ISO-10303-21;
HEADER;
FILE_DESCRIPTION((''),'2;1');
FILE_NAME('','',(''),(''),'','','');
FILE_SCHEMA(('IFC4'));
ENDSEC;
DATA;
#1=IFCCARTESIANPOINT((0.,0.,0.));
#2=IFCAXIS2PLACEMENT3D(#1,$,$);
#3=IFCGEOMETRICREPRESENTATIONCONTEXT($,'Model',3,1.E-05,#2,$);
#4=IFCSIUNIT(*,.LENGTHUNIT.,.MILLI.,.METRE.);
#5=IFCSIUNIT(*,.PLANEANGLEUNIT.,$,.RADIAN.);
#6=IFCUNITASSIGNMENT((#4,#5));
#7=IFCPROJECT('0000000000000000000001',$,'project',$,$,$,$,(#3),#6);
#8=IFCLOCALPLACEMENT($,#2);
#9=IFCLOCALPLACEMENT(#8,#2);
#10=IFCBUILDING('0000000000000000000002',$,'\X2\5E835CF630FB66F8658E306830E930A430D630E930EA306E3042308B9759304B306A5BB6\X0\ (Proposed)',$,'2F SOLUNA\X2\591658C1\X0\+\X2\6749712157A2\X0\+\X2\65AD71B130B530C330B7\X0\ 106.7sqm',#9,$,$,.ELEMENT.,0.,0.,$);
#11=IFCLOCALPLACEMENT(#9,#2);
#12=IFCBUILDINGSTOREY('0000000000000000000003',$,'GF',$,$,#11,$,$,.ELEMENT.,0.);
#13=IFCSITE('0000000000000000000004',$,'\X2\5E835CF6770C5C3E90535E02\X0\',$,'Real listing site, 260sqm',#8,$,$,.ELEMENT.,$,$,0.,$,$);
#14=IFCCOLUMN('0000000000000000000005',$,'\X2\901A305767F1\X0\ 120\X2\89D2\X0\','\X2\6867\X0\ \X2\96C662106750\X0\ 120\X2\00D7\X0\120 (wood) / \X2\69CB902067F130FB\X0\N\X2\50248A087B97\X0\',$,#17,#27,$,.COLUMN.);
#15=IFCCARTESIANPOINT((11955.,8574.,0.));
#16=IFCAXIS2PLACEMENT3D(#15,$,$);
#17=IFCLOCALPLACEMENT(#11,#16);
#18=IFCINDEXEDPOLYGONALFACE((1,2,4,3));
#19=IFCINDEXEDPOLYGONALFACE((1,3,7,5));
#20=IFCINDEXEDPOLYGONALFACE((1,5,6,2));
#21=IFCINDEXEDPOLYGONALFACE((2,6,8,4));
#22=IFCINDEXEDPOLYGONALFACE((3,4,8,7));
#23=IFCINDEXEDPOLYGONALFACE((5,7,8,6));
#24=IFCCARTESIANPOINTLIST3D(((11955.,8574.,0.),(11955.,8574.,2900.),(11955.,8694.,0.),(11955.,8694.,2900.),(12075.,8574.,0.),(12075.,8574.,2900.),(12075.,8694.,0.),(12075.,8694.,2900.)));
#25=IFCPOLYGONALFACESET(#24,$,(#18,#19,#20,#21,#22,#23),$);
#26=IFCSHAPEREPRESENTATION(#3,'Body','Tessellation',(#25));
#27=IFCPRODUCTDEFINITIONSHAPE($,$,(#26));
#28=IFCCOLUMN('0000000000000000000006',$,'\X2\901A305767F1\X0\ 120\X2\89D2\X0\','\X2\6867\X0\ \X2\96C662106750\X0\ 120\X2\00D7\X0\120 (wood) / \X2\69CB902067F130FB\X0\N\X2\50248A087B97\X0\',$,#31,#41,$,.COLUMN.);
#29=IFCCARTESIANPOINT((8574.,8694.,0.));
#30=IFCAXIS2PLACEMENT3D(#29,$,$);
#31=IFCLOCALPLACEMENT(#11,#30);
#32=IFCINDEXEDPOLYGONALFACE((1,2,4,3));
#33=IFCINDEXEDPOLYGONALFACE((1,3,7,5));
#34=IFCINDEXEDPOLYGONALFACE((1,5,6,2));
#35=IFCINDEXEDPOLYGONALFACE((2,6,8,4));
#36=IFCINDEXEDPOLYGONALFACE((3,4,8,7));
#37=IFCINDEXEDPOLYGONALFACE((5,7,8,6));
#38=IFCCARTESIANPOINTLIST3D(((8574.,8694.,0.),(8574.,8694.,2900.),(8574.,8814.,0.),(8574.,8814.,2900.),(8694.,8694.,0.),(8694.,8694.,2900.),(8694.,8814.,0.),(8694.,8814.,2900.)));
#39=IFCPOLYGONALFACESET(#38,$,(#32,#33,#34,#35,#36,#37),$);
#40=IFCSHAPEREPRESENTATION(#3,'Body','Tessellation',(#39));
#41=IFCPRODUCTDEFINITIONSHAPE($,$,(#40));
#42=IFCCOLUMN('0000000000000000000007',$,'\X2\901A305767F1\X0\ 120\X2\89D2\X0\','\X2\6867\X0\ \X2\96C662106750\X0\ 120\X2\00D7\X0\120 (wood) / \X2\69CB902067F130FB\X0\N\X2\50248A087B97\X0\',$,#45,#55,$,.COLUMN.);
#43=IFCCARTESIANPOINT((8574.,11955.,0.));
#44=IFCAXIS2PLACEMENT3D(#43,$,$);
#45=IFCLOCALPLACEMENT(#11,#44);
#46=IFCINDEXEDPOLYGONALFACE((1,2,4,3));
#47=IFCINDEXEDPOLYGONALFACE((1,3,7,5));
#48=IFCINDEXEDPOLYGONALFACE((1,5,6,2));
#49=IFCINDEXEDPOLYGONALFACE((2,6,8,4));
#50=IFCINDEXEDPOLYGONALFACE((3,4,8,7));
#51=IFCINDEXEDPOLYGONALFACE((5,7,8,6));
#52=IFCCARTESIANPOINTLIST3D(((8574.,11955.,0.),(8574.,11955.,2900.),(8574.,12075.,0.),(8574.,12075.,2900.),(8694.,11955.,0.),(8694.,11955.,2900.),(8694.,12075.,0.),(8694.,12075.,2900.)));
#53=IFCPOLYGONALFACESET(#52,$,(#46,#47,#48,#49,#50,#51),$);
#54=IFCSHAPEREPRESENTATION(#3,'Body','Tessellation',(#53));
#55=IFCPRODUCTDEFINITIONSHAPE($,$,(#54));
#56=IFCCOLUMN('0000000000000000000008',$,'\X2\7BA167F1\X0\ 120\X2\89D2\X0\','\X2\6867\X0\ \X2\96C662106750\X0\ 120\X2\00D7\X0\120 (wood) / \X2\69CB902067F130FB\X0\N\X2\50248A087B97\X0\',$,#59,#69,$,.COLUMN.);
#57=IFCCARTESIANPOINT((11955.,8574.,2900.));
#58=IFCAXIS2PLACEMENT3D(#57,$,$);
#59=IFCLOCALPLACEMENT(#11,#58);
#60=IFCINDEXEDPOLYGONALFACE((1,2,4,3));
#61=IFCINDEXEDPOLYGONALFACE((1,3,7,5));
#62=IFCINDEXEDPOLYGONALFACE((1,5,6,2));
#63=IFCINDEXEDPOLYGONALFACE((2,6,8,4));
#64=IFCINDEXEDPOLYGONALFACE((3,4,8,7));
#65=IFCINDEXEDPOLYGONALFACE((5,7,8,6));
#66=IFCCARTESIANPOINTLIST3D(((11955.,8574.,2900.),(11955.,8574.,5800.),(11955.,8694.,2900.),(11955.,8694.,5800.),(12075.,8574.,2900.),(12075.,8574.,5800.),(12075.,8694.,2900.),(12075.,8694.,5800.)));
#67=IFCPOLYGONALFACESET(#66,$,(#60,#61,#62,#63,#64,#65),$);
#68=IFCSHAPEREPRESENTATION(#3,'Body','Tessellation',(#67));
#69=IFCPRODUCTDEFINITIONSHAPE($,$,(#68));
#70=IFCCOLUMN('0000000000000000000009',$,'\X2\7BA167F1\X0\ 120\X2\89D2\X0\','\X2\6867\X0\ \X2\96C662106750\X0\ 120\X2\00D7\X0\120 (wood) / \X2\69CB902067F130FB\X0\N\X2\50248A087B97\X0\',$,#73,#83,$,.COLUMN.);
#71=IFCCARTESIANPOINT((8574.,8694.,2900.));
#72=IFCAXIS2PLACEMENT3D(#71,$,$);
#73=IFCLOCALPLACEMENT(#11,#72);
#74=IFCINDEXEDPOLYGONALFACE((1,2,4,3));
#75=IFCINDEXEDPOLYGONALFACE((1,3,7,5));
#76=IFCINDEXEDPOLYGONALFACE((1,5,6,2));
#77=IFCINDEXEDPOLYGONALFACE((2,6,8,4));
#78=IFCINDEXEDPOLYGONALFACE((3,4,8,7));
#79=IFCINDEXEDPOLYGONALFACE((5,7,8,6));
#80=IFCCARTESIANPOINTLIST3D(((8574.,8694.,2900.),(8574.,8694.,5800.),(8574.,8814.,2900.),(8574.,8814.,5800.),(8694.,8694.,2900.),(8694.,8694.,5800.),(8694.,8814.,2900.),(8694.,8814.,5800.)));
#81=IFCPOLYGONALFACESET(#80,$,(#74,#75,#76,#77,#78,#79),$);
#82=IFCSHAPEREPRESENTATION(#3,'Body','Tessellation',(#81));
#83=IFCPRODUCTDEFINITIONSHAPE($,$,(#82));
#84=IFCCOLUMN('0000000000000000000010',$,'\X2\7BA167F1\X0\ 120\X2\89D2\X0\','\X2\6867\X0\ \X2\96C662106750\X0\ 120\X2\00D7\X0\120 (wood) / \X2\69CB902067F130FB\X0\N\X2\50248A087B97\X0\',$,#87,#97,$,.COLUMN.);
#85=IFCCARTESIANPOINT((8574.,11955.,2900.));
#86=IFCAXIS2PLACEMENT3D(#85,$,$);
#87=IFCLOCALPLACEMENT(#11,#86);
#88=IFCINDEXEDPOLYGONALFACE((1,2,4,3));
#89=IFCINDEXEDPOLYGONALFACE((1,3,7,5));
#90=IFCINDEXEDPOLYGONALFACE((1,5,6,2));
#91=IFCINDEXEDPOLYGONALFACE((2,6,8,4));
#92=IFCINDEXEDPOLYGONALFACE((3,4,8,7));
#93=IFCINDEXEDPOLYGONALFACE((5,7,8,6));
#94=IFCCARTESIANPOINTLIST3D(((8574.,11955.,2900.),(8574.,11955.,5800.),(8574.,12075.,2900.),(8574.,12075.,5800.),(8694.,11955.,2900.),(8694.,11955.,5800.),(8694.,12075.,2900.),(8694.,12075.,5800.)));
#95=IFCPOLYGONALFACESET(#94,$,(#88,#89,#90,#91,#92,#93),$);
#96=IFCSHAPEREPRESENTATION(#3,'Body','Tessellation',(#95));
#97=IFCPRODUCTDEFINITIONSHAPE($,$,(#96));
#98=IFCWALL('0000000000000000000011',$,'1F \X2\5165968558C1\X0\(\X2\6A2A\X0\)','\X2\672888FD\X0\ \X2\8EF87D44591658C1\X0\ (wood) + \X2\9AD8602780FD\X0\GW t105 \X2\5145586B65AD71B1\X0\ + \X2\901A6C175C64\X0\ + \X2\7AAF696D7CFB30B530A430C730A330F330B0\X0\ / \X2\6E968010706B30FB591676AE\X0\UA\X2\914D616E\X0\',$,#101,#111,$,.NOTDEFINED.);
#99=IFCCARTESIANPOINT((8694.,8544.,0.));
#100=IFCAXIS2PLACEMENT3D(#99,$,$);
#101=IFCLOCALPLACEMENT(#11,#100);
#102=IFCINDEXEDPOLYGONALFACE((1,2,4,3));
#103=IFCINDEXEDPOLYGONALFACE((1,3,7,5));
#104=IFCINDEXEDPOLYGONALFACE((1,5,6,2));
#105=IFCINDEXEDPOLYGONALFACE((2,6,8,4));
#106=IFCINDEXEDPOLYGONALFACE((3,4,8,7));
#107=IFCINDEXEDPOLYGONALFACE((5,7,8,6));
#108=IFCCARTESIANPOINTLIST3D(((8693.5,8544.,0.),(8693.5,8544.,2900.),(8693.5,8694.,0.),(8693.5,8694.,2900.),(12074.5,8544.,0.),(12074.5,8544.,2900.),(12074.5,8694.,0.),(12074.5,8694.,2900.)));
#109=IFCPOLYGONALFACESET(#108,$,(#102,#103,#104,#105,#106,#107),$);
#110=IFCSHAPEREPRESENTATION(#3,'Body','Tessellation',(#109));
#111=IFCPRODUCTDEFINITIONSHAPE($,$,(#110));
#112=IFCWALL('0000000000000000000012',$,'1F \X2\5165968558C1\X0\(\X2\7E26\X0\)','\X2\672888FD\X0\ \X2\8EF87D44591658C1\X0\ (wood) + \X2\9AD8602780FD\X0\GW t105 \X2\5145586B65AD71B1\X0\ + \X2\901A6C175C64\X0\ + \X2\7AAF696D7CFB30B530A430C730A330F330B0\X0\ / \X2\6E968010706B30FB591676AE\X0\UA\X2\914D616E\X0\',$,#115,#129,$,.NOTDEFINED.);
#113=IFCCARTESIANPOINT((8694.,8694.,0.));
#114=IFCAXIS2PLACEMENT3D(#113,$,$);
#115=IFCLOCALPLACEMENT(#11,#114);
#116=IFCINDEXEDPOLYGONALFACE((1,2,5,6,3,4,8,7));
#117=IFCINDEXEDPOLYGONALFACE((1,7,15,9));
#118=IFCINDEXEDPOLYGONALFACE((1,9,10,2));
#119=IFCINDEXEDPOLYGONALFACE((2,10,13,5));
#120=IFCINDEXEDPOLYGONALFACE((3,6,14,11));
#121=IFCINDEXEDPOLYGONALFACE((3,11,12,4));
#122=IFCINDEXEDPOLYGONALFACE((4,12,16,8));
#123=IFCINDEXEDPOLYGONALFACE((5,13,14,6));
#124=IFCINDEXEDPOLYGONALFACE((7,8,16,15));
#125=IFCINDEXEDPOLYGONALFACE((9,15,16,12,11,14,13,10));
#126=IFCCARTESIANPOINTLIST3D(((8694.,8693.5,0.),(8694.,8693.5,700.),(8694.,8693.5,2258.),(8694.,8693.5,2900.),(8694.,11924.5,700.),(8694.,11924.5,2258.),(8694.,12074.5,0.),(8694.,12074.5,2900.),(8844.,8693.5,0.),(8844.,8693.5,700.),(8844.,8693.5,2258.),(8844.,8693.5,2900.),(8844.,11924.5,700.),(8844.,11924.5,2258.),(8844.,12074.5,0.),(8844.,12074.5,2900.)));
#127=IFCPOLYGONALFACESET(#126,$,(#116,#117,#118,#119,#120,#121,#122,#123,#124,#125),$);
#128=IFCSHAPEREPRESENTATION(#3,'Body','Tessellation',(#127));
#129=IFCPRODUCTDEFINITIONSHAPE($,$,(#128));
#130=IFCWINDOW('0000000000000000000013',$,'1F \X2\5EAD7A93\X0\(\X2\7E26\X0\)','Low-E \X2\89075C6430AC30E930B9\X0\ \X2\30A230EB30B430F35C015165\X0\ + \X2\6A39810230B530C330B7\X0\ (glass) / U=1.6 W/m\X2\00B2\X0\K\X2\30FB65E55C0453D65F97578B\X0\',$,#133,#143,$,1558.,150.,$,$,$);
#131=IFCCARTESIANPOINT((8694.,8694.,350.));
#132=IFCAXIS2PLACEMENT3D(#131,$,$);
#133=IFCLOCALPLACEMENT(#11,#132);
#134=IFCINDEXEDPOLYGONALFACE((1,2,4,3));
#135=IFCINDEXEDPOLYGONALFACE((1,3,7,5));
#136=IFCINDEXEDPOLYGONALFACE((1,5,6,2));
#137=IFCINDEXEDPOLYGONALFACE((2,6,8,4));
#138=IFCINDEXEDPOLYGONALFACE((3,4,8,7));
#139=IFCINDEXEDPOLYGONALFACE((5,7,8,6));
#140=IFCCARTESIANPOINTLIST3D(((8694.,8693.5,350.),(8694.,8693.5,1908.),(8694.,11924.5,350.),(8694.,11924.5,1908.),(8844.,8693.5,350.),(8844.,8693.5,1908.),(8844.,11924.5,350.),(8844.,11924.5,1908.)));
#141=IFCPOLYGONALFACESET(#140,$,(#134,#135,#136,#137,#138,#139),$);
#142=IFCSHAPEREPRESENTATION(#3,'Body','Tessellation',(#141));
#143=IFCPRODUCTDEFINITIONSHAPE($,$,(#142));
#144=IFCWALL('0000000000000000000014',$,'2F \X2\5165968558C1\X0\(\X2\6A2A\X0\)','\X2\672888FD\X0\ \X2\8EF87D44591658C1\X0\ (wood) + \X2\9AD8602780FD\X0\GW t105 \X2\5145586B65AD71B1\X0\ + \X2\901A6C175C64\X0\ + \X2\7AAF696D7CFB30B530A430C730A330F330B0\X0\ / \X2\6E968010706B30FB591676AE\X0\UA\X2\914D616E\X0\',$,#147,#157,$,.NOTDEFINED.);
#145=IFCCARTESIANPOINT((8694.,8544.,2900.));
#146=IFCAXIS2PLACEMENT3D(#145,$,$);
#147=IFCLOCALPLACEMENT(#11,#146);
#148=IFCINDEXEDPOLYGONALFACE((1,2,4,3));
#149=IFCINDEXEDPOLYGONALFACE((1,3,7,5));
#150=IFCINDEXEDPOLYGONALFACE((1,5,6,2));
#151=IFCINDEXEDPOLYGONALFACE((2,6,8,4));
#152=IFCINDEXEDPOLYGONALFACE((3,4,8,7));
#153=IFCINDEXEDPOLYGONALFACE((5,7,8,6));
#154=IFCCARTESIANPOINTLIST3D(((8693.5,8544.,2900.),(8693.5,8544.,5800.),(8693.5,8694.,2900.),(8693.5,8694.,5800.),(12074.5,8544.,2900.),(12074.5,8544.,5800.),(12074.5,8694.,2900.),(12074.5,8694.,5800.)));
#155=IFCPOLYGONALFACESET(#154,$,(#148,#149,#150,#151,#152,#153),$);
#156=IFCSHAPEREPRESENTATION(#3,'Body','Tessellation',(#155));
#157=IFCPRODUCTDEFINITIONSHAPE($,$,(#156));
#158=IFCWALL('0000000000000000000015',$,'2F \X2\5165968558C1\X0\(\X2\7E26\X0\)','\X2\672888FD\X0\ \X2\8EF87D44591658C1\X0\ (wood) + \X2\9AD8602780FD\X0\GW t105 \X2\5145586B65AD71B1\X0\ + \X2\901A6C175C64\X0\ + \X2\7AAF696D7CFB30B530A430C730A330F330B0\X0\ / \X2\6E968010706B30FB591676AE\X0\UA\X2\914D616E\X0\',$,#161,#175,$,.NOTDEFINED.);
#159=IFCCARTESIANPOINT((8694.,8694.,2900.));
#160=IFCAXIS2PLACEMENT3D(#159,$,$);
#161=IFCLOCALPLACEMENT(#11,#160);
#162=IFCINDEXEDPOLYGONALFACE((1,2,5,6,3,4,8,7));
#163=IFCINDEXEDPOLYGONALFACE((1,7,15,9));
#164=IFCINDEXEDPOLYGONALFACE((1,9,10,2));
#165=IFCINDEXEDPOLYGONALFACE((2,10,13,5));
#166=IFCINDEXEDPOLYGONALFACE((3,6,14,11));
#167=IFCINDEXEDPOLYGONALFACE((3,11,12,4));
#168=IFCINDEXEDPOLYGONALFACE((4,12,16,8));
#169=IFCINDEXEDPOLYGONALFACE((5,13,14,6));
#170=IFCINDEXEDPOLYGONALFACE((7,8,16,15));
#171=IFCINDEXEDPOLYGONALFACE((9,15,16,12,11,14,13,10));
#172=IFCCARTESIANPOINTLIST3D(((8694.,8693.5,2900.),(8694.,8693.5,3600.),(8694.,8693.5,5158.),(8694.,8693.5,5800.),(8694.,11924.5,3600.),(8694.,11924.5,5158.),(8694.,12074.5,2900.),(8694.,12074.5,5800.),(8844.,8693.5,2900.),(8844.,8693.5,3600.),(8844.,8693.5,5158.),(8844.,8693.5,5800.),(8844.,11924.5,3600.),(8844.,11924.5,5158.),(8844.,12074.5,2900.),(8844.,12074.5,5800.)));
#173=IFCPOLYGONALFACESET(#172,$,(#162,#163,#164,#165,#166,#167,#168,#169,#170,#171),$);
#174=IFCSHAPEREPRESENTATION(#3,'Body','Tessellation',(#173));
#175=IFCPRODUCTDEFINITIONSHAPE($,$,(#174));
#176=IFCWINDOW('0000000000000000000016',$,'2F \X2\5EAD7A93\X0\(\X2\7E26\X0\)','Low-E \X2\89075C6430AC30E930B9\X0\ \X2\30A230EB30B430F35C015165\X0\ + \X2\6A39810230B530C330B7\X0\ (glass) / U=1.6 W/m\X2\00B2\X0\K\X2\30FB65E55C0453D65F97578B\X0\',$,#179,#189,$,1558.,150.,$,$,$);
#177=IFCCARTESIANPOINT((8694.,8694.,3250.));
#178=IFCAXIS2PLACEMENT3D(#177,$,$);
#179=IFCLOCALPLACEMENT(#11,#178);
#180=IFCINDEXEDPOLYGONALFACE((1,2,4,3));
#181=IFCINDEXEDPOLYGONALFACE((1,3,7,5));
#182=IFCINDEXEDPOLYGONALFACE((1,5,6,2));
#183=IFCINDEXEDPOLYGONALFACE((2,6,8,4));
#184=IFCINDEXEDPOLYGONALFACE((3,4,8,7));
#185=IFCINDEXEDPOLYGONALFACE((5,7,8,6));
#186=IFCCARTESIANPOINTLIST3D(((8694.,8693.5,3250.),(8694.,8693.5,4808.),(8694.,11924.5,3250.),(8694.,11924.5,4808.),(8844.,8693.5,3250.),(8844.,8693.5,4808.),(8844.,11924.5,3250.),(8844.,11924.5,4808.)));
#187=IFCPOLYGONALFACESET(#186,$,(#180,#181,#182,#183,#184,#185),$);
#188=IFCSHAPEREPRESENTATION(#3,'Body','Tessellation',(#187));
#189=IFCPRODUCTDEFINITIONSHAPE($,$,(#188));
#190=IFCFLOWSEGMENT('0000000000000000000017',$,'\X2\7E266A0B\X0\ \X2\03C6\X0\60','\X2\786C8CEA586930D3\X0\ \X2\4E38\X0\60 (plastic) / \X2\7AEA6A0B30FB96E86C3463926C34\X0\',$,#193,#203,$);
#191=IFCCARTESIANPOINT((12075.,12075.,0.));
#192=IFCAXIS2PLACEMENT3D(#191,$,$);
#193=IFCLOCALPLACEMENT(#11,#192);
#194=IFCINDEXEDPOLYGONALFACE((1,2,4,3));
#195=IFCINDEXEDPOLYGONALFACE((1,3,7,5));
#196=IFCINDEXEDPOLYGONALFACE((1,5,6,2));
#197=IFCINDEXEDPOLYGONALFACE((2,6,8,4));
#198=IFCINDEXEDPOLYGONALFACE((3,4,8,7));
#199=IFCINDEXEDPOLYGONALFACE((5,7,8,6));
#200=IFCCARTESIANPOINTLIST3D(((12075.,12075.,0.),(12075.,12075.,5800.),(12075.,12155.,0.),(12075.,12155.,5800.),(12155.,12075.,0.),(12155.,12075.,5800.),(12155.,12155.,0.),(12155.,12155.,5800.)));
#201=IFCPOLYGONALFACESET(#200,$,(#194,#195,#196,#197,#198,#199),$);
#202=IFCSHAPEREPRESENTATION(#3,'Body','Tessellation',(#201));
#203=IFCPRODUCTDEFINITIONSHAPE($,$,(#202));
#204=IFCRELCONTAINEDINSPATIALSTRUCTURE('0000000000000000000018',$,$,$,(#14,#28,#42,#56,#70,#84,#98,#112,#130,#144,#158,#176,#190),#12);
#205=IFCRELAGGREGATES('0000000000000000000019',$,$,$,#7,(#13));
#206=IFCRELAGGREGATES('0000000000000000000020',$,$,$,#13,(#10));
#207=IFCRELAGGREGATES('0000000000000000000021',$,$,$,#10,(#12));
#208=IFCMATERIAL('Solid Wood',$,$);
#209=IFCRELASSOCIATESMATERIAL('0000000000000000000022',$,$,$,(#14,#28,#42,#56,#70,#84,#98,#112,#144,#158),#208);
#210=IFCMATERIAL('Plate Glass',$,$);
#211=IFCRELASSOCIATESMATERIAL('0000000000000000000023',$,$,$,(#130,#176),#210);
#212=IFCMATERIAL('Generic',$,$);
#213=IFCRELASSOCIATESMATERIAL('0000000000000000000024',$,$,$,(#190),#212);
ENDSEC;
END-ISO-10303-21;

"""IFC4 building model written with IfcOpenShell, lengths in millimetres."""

from ifc_helpers import new_model, si_unit, frame, frame_2d, origin, place, context, project, spatial, rectangle, extrude, material, element, fill, save


model = new_model("IFC4")

# Units and contexts
model_context = context("Model", 3, precision=1e-05, world=origin())
ifc_project = project(units=[si_unit("LENGTHUNIT", "METRE", prefix="MILLI"), si_unit("PLANEANGLEUNIT", "RADIAN")], contexts=[model_context])

# Site, building, storey
site_placement = place(None, origin())
site = spatial("IfcSite", under=ifc_project, at=site_placement, Name="広島県尾道市", ObjectType="Real listing site, 260sqm", CompositionType="ELEMENT", RefElevation=0.0)
building_placement = place(site_placement, origin())
building = spatial("IfcBuilding", under=site, at=building_placement, Name="広島・書斎とライブラリのある静かな家 (Proposed)", ObjectType="2F SOLUNA外壁+杉無垢+断熱サッシ 106.7sqm", CompositionType="ELEMENT", ElevationOfRefHeight=0.0, ElevationOfTerrain=0.0)
storey_placement = place(building_placement, origin())
storey = spatial("IfcBuildingStorey", under=building, at=storey_placement, Name="GF", CompositionType="ELEMENT", Elevation=0.0)

# Columns
ifc_material_1 = material(Name="Solid Wood")
column_1_placement = place(storey_placement, frame((11955.0, 8574.0, 0.0)))
element("IfcColumn", 1, at=column_1_placement, inside=storey, material=ifc_material_1, Name="通し柱 120角", Description="桧 集成材 120×120 (wood) / 構造柱・N値計算", PredefinedType="COLUMN", context=model_context, shape_type="SweptSolid", body=[
    extrude(rectangle(XDim=120.0, YDim=120.0, at=frame_2d((60.0, 60.0))), frame((11955.0, 8574.0, 0.0)), (0.0, 0.0, 1.0), 2900.0),
])
column_2_placement = place(storey_placement, frame((8574.0, 8694.0, 0.0)))
element("IfcColumn", 2, at=column_2_placement, inside=storey, material=ifc_material_1, Name="通し柱 120角", Description="桧 集成材 120×120 (wood) / 構造柱・N値計算", PredefinedType="COLUMN", context=model_context, shape_type="SweptSolid", body=[
    extrude(rectangle(XDim=120.0, YDim=120.0, at=frame_2d((60.0, 60.0))), frame((8574.0, 8694.0, 0.0)), (0.0, 0.0, 1.0), 2900.0),
])
column_3_placement = place(storey_placement, frame((8574.0, 11955.0, 0.0)))
element("IfcColumn", 3, at=column_3_placement, inside=storey, material=ifc_material_1, Name="通し柱 120角", Description="桧 集成材 120×120 (wood) / 構造柱・N値計算", PredefinedType="COLUMN", context=model_context, shape_type="SweptSolid", body=[
    extrude(rectangle(XDim=120.0, YDim=120.0, at=frame_2d((60.0, 60.0))), frame((8574.0, 11955.0, 0.0)), (0.0, 0.0, 1.0), 2900.0),
])
column_4_placement = place(storey_placement, frame((11955.0, 8574.0, 2900.0)))
element("IfcColumn", 4, at=column_4_placement, inside=storey, material=ifc_material_1, Name="管柱 120角", Description="桧 集成材 120×120 (wood) / 構造柱・N値計算", PredefinedType="COLUMN", context=model_context, shape_type="SweptSolid", body=[
    extrude(rectangle(XDim=120.0, YDim=120.0, at=frame_2d((60.0, 60.0))), frame((11955.0, 8574.0, 2900.0)), (0.0, 0.0, 1.0), 2900.0),
])
column_5_placement = place(storey_placement, frame((8574.0, 8694.0, 2900.0)))
element("IfcColumn", 5, at=column_5_placement, inside=storey, material=ifc_material_1, Name="管柱 120角", Description="桧 集成材 120×120 (wood) / 構造柱・N値計算", PredefinedType="COLUMN", context=model_context, shape_type="SweptSolid", body=[
    extrude(rectangle(XDim=120.0, YDim=120.0, at=frame_2d((60.0, 60.0))), frame((8574.0, 8694.0, 2900.0)), (0.0, 0.0, 1.0), 2900.0),
])
column_6_placement = place(storey_placement, frame((8574.0, 11955.0, 2900.0)))
element("IfcColumn", 6, at=column_6_placement, inside=storey, material=ifc_material_1, Name="管柱 120角", Description="桧 集成材 120×120 (wood) / 構造柱・N値計算", PredefinedType="COLUMN", context=model_context, shape_type="SweptSolid", body=[
    extrude(rectangle(XDim=120.0, YDim=120.0, at=frame_2d((60.0, 60.0))), frame((8574.0, 11955.0, 2900.0)), (0.0, 0.0, 1.0), 2900.0),
])

# Wall
wall_1_placement = place(storey_placement, frame((8694.0, 8544.0, 0.0)))
element("IfcWall", 7, at=wall_1_placement, inside=storey, material=ifc_material_1, Name="1F 入隅壁(横)", Description="木製 軸組外壁 (wood) + 高性能GW t105 充填断熱 + 通気層 + 窯業系サイディング / 準耐火・外皮UA配慮", PredefinedType="NOTDEFINED", context=model_context, shape_type="SweptSolid", body=[
    extrude(rectangle(XDim=3381.0, YDim=150.0, at=frame_2d((1690.0, 75.0))), frame((8694.0, 8544.0, 0.0)), (0.0, 0.0, 1.0), 2900.0),
])

# Wall, opening, window
wall_2_placement = place(storey_placement, frame((8694.0, 8694.0, 0.0)))
wall_2 = element("IfcWall", 8, at=wall_2_placement, inside=storey, material=ifc_material_1, Name="1F 入隅壁(縦)", Description="木製 軸組外壁 (wood) + 高性能GW t105 充填断熱 + 通気層 + 窯業系サイディング / 準耐火・外皮UA配慮", PredefinedType="NOTDEFINED", context=model_context, shape_type="SweptSolid", body=[
    extrude(rectangle(XDim=150.0, YDim=3381.0, at=frame_2d((75.0, 1690.0))), frame((8694.0, 8694.0, 0.0)), (0.0, 0.0, 1.0), 2900.0),
])
opening_1_placement = place(storey_placement, frame((8694.0, 8694.0, 350.0)))
opening_1 = element("IfcOpeningElement", 9, at=opening_1_placement, cuts=wall_2, PredefinedType="NOTDEFINED", context=model_context, shape_type="SweptSolid", body=[
    extrude(rectangle(XDim=150.0, YDim=3231.0, at=frame_2d((75.0, 1615.0))), frame((8694.0, 8694.0, 350.0)), (0.0, 0.0, 1.0), 1558.0),
])
ifc_material_2 = material(Name="Plate Glass")
window_1_placement = place(storey_placement, frame((8694.0, 8694.0, 350.0)))
window_1 = element("IfcWindow", 10, at=window_1_placement, inside=storey, material=ifc_material_2, Name="1F 庭窓(縦)", Description="Low-E 複層ガラス アルゴン封入 + 樹脂サッシ (glass) / U=1.6 W/m²K・日射取得型", OverallHeight=1558.0, OverallWidth=150.0, context=model_context, shape_type="SweptSolid", body=[
    extrude(rectangle(XDim=150.0, YDim=3231.0, at=frame_2d((75.0, 1615.0))), frame((8694.0, 8694.0, 350.0)), (0.0, 0.0, 1.0), 1558.0),
])
fill(opening_1, window_1)

# Wall
wall_3_placement = place(storey_placement, frame((8694.0, 8544.0, 2900.0)))
element("IfcWall", 11, at=wall_3_placement, inside=storey, material=ifc_material_1, Name="2F 入隅壁(横)", Description="木製 軸組外壁 (wood) + 高性能GW t105 充填断熱 + 通気層 + 窯業系サイディング / 準耐火・外皮UA配慮", PredefinedType="NOTDEFINED", context=model_context, shape_type="SweptSolid", body=[
    extrude(rectangle(XDim=3381.0, YDim=150.0, at=frame_2d((1690.0, 75.0))), frame((8694.0, 8544.0, 2900.0)), (0.0, 0.0, 1.0), 2900.0),
])

# Wall, opening, window
wall_4_placement = place(storey_placement, frame((8694.0, 8694.0, 2900.0)))
wall_4 = element("IfcWall", 12, at=wall_4_placement, inside=storey, material=ifc_material_1, Name="2F 入隅壁(縦)", Description="木製 軸組外壁 (wood) + 高性能GW t105 充填断熱 + 通気層 + 窯業系サイディング / 準耐火・外皮UA配慮", PredefinedType="NOTDEFINED", context=model_context, shape_type="SweptSolid", body=[
    extrude(rectangle(XDim=150.0, YDim=3381.0, at=frame_2d((75.0, 1690.0))), frame((8694.0, 8694.0, 2900.0)), (0.0, 0.0, 1.0), 2900.0),
])
opening_2_placement = place(storey_placement, frame((8694.0, 8694.0, 3250.0)))
opening_2 = element("IfcOpeningElement", 13, at=opening_2_placement, cuts=wall_4, PredefinedType="NOTDEFINED", context=model_context, shape_type="SweptSolid", body=[
    extrude(rectangle(XDim=150.0, YDim=3231.0, at=frame_2d((75.0, 1615.0))), frame((8694.0, 8694.0, 3250.0)), (0.0, 0.0, 1.0), 1558.0),
])
window_2_placement = place(storey_placement, frame((8694.0, 8694.0, 3250.0)))
window_2 = element("IfcWindow", 14, at=window_2_placement, inside=storey, material=ifc_material_2, Name="2F 庭窓(縦)", Description="Low-E 複層ガラス アルゴン封入 + 樹脂サッシ (glass) / U=1.6 W/m²K・日射取得型", OverallHeight=1558.0, OverallWidth=150.0, context=model_context, shape_type="SweptSolid", body=[
    extrude(rectangle(XDim=150.0, YDim=3231.0, at=frame_2d((75.0, 1615.0))), frame((8694.0, 8694.0, 3250.0)), (0.0, 0.0, 1.0), 1558.0),
])
fill(opening_2, window_2)

# Flow segment
ifc_material_3 = material(Name="Generic")
flow_segment_placement = place(storey_placement, frame((12075.0, 12075.0, 0.0)))
element("IfcFlowSegment", 15, at=flow_segment_placement, inside=storey, material=ifc_material_3, Name="縦樋 φ60", Description="硬質塩ビ 丸60 (plastic) / 竪樋・雨水排水", context=model_context, shape_type="SweptSolid", body=[
    extrude(rectangle(XDim=80.0, YDim=80.0, at=frame_2d((40.0, 40.0))), frame((12075.0, 12075.0, 0.0)), (0.0, 0.0, 1.0), 5800.0),
])

save(model, "model.ifc")
